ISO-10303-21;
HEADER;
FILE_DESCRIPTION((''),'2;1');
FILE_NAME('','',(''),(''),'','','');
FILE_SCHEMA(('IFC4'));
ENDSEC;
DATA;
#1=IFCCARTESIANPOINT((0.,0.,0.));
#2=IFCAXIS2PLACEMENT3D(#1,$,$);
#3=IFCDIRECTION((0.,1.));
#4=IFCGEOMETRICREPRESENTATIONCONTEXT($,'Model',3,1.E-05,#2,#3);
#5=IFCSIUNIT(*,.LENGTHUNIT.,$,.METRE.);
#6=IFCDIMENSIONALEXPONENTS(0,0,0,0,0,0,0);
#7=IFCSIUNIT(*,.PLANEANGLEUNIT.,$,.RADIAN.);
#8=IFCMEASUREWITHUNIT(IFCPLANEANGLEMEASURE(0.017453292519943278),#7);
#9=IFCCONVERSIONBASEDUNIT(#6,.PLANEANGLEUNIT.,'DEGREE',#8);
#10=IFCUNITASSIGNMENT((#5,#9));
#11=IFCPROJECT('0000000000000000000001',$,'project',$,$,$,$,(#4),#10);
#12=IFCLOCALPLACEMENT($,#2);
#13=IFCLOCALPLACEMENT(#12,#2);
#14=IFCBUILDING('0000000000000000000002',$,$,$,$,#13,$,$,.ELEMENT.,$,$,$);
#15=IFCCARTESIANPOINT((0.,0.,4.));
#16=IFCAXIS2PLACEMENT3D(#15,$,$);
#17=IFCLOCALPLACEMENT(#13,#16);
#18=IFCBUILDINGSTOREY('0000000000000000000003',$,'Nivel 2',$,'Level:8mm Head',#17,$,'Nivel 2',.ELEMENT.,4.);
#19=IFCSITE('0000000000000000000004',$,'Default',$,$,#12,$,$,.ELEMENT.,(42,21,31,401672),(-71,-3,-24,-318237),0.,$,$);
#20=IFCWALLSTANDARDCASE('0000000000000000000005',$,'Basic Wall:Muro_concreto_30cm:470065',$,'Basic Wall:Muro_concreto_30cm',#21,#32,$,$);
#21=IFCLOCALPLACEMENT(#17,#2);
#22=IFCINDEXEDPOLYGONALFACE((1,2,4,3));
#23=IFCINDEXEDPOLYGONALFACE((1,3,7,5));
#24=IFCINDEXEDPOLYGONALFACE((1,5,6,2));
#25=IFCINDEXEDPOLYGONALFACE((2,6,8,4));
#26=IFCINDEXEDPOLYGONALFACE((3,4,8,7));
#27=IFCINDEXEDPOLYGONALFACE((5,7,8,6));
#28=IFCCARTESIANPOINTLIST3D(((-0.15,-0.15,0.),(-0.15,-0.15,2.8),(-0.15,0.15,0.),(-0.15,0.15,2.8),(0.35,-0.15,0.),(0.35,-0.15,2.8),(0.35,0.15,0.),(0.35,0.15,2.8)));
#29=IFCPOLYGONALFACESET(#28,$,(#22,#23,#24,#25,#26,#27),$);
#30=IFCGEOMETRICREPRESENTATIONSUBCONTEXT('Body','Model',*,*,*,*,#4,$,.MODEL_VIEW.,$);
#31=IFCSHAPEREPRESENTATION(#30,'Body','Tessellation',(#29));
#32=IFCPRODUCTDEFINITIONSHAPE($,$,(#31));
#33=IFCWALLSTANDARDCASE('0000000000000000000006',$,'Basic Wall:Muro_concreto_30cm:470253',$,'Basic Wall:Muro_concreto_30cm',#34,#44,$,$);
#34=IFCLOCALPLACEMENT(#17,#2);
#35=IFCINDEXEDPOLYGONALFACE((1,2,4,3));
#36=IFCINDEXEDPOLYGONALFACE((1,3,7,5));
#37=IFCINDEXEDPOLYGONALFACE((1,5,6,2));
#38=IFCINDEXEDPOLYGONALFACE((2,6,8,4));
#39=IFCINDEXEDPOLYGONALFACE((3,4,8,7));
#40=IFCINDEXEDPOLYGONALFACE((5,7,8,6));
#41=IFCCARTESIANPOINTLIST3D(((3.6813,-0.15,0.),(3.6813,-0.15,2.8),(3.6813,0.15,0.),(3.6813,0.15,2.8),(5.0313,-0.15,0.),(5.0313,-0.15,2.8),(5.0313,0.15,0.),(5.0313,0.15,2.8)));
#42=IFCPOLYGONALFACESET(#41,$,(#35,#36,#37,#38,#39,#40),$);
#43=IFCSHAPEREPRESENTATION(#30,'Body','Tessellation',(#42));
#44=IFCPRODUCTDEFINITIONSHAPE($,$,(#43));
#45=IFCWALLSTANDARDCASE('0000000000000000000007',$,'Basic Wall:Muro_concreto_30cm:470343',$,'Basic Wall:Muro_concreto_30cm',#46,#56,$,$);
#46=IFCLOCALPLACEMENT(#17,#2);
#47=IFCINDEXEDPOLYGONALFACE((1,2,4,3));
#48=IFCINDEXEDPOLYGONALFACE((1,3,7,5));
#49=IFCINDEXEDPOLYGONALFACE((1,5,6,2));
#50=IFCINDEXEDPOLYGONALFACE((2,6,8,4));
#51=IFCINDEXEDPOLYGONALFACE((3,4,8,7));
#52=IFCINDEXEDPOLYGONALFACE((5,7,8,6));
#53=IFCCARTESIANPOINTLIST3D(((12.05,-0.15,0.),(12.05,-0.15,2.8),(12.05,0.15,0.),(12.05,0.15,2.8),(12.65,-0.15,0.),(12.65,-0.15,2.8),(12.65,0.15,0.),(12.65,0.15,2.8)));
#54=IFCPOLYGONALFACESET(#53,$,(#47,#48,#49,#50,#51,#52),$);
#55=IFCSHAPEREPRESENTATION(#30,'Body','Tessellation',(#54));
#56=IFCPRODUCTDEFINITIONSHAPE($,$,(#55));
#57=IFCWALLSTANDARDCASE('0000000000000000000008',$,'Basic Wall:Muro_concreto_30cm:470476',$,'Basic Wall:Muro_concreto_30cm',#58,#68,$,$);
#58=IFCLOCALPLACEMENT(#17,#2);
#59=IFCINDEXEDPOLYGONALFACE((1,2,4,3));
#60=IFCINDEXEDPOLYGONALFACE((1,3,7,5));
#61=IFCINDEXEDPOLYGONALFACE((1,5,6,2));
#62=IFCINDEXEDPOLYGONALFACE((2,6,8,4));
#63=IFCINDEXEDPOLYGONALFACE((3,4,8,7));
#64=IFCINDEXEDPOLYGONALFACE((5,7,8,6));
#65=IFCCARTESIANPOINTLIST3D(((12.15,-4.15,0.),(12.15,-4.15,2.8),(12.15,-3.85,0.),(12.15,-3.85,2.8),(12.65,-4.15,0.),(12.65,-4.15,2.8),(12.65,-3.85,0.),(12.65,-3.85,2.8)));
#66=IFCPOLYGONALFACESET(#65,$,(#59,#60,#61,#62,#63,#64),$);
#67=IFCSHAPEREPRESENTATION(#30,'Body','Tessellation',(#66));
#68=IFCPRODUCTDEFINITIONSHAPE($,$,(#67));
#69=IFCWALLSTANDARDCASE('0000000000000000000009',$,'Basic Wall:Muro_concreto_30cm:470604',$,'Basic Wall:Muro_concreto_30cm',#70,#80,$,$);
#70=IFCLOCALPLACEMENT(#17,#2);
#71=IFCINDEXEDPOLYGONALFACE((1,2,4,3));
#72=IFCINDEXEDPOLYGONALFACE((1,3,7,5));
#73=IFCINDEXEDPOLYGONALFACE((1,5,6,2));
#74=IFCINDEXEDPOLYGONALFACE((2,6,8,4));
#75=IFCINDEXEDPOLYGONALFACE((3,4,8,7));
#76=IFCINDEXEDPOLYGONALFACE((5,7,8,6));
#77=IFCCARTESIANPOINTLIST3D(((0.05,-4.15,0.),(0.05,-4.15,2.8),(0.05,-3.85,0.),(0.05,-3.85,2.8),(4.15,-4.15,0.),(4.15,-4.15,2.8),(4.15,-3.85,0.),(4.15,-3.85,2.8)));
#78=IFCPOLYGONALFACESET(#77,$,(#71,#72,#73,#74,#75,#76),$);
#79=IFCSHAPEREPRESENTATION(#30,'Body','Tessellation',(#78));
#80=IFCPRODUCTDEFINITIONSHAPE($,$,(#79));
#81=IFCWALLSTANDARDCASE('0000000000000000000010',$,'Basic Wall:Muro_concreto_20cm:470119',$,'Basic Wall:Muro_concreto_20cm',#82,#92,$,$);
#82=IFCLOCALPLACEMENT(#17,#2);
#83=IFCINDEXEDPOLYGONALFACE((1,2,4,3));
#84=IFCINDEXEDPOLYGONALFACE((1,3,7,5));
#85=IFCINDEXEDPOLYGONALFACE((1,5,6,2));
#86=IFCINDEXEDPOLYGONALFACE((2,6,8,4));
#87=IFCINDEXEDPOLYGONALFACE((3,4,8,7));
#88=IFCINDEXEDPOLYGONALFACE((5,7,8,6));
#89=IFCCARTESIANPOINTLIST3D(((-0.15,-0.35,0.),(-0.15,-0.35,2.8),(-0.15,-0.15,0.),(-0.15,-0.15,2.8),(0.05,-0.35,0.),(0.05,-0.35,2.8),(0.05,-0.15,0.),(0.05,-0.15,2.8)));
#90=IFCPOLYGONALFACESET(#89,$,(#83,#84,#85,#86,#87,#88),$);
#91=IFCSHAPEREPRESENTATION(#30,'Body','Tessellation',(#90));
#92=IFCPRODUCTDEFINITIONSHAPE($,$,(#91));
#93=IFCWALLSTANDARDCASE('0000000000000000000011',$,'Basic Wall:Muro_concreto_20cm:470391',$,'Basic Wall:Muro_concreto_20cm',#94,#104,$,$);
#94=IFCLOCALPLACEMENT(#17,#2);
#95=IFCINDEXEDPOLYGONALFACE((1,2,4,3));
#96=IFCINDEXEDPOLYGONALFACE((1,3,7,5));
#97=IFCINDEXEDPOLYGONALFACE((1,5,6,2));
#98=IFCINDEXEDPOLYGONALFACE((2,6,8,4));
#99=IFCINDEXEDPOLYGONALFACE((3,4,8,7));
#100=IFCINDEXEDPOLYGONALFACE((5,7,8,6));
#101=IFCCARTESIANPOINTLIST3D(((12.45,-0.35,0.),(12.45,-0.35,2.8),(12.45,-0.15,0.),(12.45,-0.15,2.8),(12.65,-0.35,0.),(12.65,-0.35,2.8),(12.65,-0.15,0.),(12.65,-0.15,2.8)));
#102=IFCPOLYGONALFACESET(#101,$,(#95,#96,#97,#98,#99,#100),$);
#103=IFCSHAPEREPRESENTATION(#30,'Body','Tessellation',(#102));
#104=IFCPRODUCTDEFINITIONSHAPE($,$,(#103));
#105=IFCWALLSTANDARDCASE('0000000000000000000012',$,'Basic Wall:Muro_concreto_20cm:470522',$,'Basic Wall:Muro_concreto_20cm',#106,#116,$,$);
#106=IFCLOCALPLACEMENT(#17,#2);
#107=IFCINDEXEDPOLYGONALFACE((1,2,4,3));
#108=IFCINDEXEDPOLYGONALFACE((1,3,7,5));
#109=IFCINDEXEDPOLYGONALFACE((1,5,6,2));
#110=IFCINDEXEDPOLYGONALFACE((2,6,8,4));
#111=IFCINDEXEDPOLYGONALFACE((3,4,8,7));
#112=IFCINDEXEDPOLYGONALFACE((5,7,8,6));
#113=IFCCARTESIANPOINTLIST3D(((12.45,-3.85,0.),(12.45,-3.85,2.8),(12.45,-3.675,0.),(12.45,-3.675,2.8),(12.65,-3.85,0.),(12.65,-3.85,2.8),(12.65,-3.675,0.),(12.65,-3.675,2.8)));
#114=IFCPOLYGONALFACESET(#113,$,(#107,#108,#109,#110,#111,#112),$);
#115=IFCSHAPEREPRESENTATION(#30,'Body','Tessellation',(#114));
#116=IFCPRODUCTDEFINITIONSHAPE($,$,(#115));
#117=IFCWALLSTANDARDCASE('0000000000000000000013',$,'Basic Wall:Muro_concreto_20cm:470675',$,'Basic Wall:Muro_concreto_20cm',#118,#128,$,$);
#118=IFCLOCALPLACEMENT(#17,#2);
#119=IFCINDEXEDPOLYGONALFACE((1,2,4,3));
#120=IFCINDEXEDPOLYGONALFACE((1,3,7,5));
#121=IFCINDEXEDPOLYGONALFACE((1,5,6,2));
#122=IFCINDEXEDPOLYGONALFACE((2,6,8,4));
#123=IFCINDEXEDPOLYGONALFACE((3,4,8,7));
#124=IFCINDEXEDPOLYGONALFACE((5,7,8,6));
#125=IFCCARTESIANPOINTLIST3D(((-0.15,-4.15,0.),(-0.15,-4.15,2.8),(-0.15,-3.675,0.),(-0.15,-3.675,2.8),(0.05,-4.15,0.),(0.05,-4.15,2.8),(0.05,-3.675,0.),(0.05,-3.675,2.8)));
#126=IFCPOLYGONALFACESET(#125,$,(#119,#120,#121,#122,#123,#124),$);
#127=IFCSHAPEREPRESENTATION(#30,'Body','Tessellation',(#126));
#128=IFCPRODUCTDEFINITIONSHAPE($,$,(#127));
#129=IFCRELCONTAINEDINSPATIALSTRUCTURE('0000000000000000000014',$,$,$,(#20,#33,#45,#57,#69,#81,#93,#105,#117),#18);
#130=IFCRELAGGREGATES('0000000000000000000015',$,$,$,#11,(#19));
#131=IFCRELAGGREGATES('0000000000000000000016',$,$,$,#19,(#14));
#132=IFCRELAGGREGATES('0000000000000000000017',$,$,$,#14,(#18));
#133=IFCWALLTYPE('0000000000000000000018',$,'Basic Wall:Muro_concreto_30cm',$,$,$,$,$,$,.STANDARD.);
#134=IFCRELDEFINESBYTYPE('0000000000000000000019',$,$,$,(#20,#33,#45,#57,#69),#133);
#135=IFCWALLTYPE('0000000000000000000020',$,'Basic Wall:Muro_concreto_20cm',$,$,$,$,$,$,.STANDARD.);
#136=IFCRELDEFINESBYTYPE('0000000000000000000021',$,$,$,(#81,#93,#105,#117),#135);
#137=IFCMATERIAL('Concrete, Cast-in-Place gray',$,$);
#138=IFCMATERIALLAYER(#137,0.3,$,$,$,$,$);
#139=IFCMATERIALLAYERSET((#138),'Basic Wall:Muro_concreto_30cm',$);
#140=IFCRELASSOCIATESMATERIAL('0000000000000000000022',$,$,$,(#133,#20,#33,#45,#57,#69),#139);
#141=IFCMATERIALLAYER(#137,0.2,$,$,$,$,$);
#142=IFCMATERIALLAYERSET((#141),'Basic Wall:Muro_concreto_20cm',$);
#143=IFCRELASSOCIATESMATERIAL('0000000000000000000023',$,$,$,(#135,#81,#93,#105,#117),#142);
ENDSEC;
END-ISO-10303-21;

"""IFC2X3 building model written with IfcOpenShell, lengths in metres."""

from ifc_helpers import new_model, entity, si_unit, converted_unit, direction, frame, frame_2d, origin, place, context, subcontext, project, spatial, polyline, rectangle, extrude, clip, bounded_halfspace, material, layer, layer_set, layer_usage, type_object, element, save


model = new_model("IFC2X3")

# Units and contexts
model_context = context("Model", 3, precision=1e-05, world=origin(), true_north=direction((0.0, 1.0)))
body_context = subcontext(model_context, "Body", "Model", "MODEL_VIEW")
ifc_project = project(units=[si_unit("LENGTHUNIT", "METRE"), converted_unit("PLANEANGLEUNIT", "DEGREE", entity("IfcPlaneAngleMeasure", 0.017453292519943278), si_unit("PLANEANGLEUNIT", "RADIAN"), dimensions=[0, 0, 0, 0, 0, 0, 0])], contexts=[model_context])

# Site, building, storey
site_placement = place(None, origin())
site = spatial("IfcSite", under=ifc_project, at=site_placement, Name="Default", CompositionType="ELEMENT", RefLatitude=(42, 21, 31, 401672), RefLongitude=(-71, -3, -24, -318237), RefElevation=0.0)
building_placement = place(site_placement, origin())
building = spatial("IfcBuilding", under=site, at=building_placement, CompositionType="ELEMENT")
storey_placement = place(building_placement, frame((0.0, 0.0, 4.0)))
storey = spatial("IfcBuildingStorey", under=building, at=storey_placement, Name="Nivel 2", ObjectType="Level:8mm Head", LongName="Nivel 2", CompositionType="ELEMENT", Elevation=4.0)

# Shared definitions
ifc_material_1 = material(Name="Concrete, Cast-in-Place gray")

# Walls
ifc_layer_1 = layer(ifc_material_1, 0.3)
ifc_layer_set_1 = layer_set([ifc_layer_1], Name="Basic Wall:Muro_concreto_30cm")
ifc_layer_usage_1 = layer_usage(ifc_layer_set_1, "AXIS2", "NEGATIVE", 0.15)
wall_type_1 = type_object("IfcWallType", Name="Basic Wall:Muro_concreto_30cm", PredefinedType="STANDARD", material=ifc_layer_set_1)
wall_1_placement = place(storey_placement, frame((-0.15, 0.0, 0.0)))
element("IfcWallStandardCase", 1, at=wall_1_placement, inside=storey, type_object=wall_type_1, material=ifc_layer_usage_1, Name="Basic Wall:Muro_concreto_30cm:470065", ObjectType="Basic Wall:Muro_concreto_30cm", context=body_context, shape_type="Clipping", body=[
    clip(extrude(rectangle(XDim=0.5, YDim=0.3, at=frame_2d((0.25, 0.0), x_axis=(-1.0, 0.0))), origin(), (0.0, 0.0, 1.0), 2.8), bounded_halfspace(frame((0.0, -0.15, 2.8), z_axis=(0.0, 0.0, -1.0), x_axis=(0.0, -1.0, 0.0)), True, frame((0.0, -0.15, 2.8)), polyline([(0.0, 0.0), (0.2, 0.0), (0.5, 0.0), (0.5, 0.3), (0.0, 0.3), (0.0, 0.0)]))),
])
ifc_layer_usage_2 = layer_usage(ifc_layer_set_1, "AXIS2", "NEGATIVE", 0.15)
wall_2_placement = place(storey_placement, frame((5.0313, 0.0, 0.0), z_axis=(0.0, 0.0, 1.0), x_axis=(-1.0, 0.0, 0.0)))
element("IfcWallStandardCase", 2, at=wall_2_placement, inside=storey, type_object=wall_type_1, material=ifc_layer_usage_2, Name="Basic Wall:Muro_concreto_30cm:470253", ObjectType="Basic Wall:Muro_concreto_30cm", context=body_context, shape_type="Clipping", body=[
    clip(extrude(rectangle(XDim=1.35, YDim=0.3, at=frame_2d((0.675, 0.0), x_axis=(-1.0, 0.0))), origin(), (0.0, 0.0, 1.0), 2.8), bounded_halfspace(frame((0.0, -0.15, 2.8), z_axis=(0.0, 0.0, -1.0), x_axis=(0.0, 1.0, 0.0)), True, frame((0.0, -0.15, 2.8)), polyline([(0.0, 0.0), (1.35, 0.0), (1.35, 0.3), (0.0, 0.3), (0.0, 0.0)]))),
])
ifc_layer_usage_3 = layer_usage(ifc_layer_set_1, "AXIS2", "NEGATIVE", 0.15)
wall_3_placement = place(storey_placement, frame((12.05, 0.0, 0.0)))
element("IfcWallStandardCase", 3, at=wall_3_placement, inside=storey, type_object=wall_type_1, material=ifc_layer_usage_3, Name="Basic Wall:Muro_concreto_30cm:470343", ObjectType="Basic Wall:Muro_concreto_30cm", context=body_context, shape_type="Clipping", body=[
    clip(extrude(rectangle(XDim=0.6, YDim=0.3, at=frame_2d((0.3, 0.0), x_axis=(-1.0, 0.0))), origin(), (0.0, 0.0, 1.0), 2.8), bounded_halfspace(frame((0.0, -0.15, 2.8), z_axis=(0.0, 0.0, -1.0), x_axis=(0.0, -1.0, 0.0)), True, frame((0.0, -0.15, 2.8)), polyline([(0.0, 0.0), (0.4, 0.0), (0.6, 0.0), (0.6, 0.3), (0.0, 0.3), (0.0, 0.0)]))),
])
ifc_layer_usage_4 = layer_usage(ifc_layer_set_1, "AXIS2", "NEGATIVE", 0.15)
wall_4_placement = place(storey_placement, frame((12.15, -4.0, 0.0)))
element("IfcWallStandardCase", 4, at=wall_4_placement, inside=storey, type_object=wall_type_1, material=ifc_layer_usage_4, Name="Basic Wall:Muro_concreto_30cm:470476", ObjectType="Basic Wall:Muro_concreto_30cm", context=body_context, shape_type="Clipping", body=[
    clip(extrude(rectangle(XDim=0.5, YDim=0.3, at=frame_2d((0.25, 0.0), x_axis=(-1.0, 0.0))), origin(), (0.0, 0.0, 1.0), 2.8), bounded_halfspace(frame((0.0, -0.15, 2.8), z_axis=(0.0, 0.0, -1.0), x_axis=(0.0, -1.0, 0.0)), True, frame((0.0, -0.15, 2.8)), polyline([(0.0, 0.0), (0.5, 0.0), (0.5, 0.3), (0.3, 0.3), (0.0, 0.3), (0.0, 0.0)]))),
])
ifc_layer_usage_5 = layer_usage(ifc_layer_set_1, "AXIS2", "NEGATIVE", 0.15)
wall_5_placement = place(storey_placement, frame((4.15, -4.0, 0.0), z_axis=(0.0, 0.0, 1.0), x_axis=(-1.0, 0.0, 0.0)))
element("IfcWallStandardCase", 5, at=wall_5_placement, inside=storey, type_object=wall_type_1, material=ifc_layer_usage_5, Name="Basic Wall:Muro_concreto_30cm:470604", ObjectType="Basic Wall:Muro_concreto_30cm", context=body_context, shape_type="Clipping", body=[
    clip(extrude(rectangle(XDim=4.1, YDim=0.3, at=frame_2d((2.05, 0.0), x_axis=(-1.0, 0.0))), origin(), (0.0, 0.0, 1.0), 2.8), bounded_halfspace(frame((0.0, -0.15, 2.8), z_axis=(0.0, 0.0, -1.0), x_axis=(0.0, 1.0, 0.0)), True, frame((0.0, -0.15, 2.8)), polyline([(0.0, 0.0), (4.1, 0.0), (4.1, 0.3), (0.0, 0.3), (0.0, 0.0)]))),
])
ifc_layer_2 = layer(ifc_material_1, 0.2)
ifc_layer_set_2 = layer_set([ifc_layer_2], Name="Basic Wall:Muro_concreto_20cm")
ifc_layer_usage_6 = layer_usage(ifc_layer_set_2, "AXIS2", "NEGATIVE", 0.1)
wall_type_2 = type_object("IfcWallType", Name="Basic Wall:Muro_concreto_20cm", PredefinedType="STANDARD", material=ifc_layer_set_2)
wall_6_placement = place(storey_placement, frame((-0.05, -0.35, 0.0), z_axis=(0.0, 0.0, 1.0), x_axis=(0.0, 1.0, 0.0)))
element("IfcWallStandardCase", 6, at=wall_6_placement, inside=storey, type_object=wall_type_2, material=ifc_layer_usage_6, Name="Basic Wall:Muro_concreto_20cm:470119", ObjectType="Basic Wall:Muro_concreto_20cm", context=body_context, shape_type="Clipping", body=[
    clip(extrude(rectangle(XDim=0.2, YDim=0.2, at=frame_2d((0.1, 0.0), x_axis=(-1.0, 0.0))), origin(), (0.0, 0.0, 1.0), 2.8), bounded_halfspace(frame((0.0, -0.1, 2.8), z_axis=(0.0, 0.0, -1.0), x_axis=(-1.0, 0.0, 0.0)), True, frame((0.0, -0.1, 2.8)), polyline([(0.0, 0.0), (0.2, 0.0), (0.2, 0.2), (0.0, 0.2), (0.0, 0.0)]))),
])
ifc_layer_usage_7 = layer_usage(ifc_layer_set_2, "AXIS2", "NEGATIVE", 0.1)
wall_7_placement = place(storey_placement, frame((12.55, -0.35, 0.0), z_axis=(0.0, 0.0, 1.0), x_axis=(0.0, 1.0, 0.0)))
element("IfcWallStandardCase", 7, at=wall_7_placement, inside=storey, type_object=wall_type_2, material=ifc_layer_usage_7, Name="Basic Wall:Muro_concreto_20cm:470391", ObjectType="Basic Wall:Muro_concreto_20cm", context=body_context, shape_type="Clipping", body=[
    clip(extrude(rectangle(XDim=0.2, YDim=0.2, at=frame_2d((0.1, 0.0), x_axis=(-1.0, 0.0))), origin(), (0.0, 0.0, 1.0), 2.8), bounded_halfspace(frame((0.0, -0.1, 2.8), z_axis=(0.0, 0.0, -1.0), x_axis=(-1.0, 0.0, 0.0)), True, frame((0.0, -0.1, 2.8)), polyline([(0.0, 0.0), (0.2, 0.0), (0.2, 0.2), (0.0, 0.2), (0.0, 0.0)]))),
])
ifc_layer_usage_8 = layer_usage(ifc_layer_set_2, "AXIS2", "NEGATIVE", 0.1)
wall_8_placement = place(storey_placement, frame((12.55, -3.85, 0.0), z_axis=(0.0, 0.0, 1.0), x_axis=(0.0, 1.0, 0.0)))
element("IfcWallStandardCase", 8, at=wall_8_placement, inside=storey, type_object=wall_type_2, material=ifc_layer_usage_8, Name="Basic Wall:Muro_concreto_20cm:470522", ObjectType="Basic Wall:Muro_concreto_20cm", context=body_context, shape_type="Clipping", body=[
    clip(extrude(rectangle(XDim=0.175, YDim=0.2, at=frame_2d((0.0875, 0.0), x_axis=(-1.0, 0.0))), origin(), (0.0, 0.0, 1.0), 2.8), bounded_halfspace(frame((0.0, -0.1, 2.8), z_axis=(0.0, 0.0, -1.0), x_axis=(-1.0, 0.0, 0.0)), True, frame((0.0, -0.1, 2.8)), polyline([(0.0, 0.0), (0.175, 0.0), (0.175, 0.2), (0.0, 0.2), (0.0, 0.0)]))),
])
ifc_layer_usage_9 = layer_usage(ifc_layer_set_2, "AXIS2", "NEGATIVE", 0.1)
wall_9_placement = place(storey_placement, frame((-0.05, -3.675, 0.0), z_axis=(0.0, 0.0, 1.0), x_axis=(0.0, -1.0, 0.0)))
element("IfcWallStandardCase", 9, at=wall_9_placement, inside=storey, type_object=wall_type_2, material=ifc_layer_usage_9, Name="Basic Wall:Muro_concreto_20cm:470675", ObjectType="Basic Wall:Muro_concreto_20cm", context=body_context, shape_type="Clipping", body=[
    clip(extrude(rectangle(XDim=0.475, YDim=0.2, at=frame_2d((0.2375, 0.0), x_axis=(-1.0, 0.0))), origin(), (0.0, 0.0, 1.0), 2.8), bounded_halfspace(frame((0.0, -0.1, 2.8), z_axis=(0.0, 0.0, -1.0), x_axis=(1.0, 0.0, 0.0)), True, frame((0.0, -0.1, 2.8)), polyline([(0.0, 0.0), (0.475, 0.0), (0.475, 0.2), (0.175, 0.2), (0.0, 0.2), (0.0, 0.0)]))),
])

save(model, "model.ifc")
